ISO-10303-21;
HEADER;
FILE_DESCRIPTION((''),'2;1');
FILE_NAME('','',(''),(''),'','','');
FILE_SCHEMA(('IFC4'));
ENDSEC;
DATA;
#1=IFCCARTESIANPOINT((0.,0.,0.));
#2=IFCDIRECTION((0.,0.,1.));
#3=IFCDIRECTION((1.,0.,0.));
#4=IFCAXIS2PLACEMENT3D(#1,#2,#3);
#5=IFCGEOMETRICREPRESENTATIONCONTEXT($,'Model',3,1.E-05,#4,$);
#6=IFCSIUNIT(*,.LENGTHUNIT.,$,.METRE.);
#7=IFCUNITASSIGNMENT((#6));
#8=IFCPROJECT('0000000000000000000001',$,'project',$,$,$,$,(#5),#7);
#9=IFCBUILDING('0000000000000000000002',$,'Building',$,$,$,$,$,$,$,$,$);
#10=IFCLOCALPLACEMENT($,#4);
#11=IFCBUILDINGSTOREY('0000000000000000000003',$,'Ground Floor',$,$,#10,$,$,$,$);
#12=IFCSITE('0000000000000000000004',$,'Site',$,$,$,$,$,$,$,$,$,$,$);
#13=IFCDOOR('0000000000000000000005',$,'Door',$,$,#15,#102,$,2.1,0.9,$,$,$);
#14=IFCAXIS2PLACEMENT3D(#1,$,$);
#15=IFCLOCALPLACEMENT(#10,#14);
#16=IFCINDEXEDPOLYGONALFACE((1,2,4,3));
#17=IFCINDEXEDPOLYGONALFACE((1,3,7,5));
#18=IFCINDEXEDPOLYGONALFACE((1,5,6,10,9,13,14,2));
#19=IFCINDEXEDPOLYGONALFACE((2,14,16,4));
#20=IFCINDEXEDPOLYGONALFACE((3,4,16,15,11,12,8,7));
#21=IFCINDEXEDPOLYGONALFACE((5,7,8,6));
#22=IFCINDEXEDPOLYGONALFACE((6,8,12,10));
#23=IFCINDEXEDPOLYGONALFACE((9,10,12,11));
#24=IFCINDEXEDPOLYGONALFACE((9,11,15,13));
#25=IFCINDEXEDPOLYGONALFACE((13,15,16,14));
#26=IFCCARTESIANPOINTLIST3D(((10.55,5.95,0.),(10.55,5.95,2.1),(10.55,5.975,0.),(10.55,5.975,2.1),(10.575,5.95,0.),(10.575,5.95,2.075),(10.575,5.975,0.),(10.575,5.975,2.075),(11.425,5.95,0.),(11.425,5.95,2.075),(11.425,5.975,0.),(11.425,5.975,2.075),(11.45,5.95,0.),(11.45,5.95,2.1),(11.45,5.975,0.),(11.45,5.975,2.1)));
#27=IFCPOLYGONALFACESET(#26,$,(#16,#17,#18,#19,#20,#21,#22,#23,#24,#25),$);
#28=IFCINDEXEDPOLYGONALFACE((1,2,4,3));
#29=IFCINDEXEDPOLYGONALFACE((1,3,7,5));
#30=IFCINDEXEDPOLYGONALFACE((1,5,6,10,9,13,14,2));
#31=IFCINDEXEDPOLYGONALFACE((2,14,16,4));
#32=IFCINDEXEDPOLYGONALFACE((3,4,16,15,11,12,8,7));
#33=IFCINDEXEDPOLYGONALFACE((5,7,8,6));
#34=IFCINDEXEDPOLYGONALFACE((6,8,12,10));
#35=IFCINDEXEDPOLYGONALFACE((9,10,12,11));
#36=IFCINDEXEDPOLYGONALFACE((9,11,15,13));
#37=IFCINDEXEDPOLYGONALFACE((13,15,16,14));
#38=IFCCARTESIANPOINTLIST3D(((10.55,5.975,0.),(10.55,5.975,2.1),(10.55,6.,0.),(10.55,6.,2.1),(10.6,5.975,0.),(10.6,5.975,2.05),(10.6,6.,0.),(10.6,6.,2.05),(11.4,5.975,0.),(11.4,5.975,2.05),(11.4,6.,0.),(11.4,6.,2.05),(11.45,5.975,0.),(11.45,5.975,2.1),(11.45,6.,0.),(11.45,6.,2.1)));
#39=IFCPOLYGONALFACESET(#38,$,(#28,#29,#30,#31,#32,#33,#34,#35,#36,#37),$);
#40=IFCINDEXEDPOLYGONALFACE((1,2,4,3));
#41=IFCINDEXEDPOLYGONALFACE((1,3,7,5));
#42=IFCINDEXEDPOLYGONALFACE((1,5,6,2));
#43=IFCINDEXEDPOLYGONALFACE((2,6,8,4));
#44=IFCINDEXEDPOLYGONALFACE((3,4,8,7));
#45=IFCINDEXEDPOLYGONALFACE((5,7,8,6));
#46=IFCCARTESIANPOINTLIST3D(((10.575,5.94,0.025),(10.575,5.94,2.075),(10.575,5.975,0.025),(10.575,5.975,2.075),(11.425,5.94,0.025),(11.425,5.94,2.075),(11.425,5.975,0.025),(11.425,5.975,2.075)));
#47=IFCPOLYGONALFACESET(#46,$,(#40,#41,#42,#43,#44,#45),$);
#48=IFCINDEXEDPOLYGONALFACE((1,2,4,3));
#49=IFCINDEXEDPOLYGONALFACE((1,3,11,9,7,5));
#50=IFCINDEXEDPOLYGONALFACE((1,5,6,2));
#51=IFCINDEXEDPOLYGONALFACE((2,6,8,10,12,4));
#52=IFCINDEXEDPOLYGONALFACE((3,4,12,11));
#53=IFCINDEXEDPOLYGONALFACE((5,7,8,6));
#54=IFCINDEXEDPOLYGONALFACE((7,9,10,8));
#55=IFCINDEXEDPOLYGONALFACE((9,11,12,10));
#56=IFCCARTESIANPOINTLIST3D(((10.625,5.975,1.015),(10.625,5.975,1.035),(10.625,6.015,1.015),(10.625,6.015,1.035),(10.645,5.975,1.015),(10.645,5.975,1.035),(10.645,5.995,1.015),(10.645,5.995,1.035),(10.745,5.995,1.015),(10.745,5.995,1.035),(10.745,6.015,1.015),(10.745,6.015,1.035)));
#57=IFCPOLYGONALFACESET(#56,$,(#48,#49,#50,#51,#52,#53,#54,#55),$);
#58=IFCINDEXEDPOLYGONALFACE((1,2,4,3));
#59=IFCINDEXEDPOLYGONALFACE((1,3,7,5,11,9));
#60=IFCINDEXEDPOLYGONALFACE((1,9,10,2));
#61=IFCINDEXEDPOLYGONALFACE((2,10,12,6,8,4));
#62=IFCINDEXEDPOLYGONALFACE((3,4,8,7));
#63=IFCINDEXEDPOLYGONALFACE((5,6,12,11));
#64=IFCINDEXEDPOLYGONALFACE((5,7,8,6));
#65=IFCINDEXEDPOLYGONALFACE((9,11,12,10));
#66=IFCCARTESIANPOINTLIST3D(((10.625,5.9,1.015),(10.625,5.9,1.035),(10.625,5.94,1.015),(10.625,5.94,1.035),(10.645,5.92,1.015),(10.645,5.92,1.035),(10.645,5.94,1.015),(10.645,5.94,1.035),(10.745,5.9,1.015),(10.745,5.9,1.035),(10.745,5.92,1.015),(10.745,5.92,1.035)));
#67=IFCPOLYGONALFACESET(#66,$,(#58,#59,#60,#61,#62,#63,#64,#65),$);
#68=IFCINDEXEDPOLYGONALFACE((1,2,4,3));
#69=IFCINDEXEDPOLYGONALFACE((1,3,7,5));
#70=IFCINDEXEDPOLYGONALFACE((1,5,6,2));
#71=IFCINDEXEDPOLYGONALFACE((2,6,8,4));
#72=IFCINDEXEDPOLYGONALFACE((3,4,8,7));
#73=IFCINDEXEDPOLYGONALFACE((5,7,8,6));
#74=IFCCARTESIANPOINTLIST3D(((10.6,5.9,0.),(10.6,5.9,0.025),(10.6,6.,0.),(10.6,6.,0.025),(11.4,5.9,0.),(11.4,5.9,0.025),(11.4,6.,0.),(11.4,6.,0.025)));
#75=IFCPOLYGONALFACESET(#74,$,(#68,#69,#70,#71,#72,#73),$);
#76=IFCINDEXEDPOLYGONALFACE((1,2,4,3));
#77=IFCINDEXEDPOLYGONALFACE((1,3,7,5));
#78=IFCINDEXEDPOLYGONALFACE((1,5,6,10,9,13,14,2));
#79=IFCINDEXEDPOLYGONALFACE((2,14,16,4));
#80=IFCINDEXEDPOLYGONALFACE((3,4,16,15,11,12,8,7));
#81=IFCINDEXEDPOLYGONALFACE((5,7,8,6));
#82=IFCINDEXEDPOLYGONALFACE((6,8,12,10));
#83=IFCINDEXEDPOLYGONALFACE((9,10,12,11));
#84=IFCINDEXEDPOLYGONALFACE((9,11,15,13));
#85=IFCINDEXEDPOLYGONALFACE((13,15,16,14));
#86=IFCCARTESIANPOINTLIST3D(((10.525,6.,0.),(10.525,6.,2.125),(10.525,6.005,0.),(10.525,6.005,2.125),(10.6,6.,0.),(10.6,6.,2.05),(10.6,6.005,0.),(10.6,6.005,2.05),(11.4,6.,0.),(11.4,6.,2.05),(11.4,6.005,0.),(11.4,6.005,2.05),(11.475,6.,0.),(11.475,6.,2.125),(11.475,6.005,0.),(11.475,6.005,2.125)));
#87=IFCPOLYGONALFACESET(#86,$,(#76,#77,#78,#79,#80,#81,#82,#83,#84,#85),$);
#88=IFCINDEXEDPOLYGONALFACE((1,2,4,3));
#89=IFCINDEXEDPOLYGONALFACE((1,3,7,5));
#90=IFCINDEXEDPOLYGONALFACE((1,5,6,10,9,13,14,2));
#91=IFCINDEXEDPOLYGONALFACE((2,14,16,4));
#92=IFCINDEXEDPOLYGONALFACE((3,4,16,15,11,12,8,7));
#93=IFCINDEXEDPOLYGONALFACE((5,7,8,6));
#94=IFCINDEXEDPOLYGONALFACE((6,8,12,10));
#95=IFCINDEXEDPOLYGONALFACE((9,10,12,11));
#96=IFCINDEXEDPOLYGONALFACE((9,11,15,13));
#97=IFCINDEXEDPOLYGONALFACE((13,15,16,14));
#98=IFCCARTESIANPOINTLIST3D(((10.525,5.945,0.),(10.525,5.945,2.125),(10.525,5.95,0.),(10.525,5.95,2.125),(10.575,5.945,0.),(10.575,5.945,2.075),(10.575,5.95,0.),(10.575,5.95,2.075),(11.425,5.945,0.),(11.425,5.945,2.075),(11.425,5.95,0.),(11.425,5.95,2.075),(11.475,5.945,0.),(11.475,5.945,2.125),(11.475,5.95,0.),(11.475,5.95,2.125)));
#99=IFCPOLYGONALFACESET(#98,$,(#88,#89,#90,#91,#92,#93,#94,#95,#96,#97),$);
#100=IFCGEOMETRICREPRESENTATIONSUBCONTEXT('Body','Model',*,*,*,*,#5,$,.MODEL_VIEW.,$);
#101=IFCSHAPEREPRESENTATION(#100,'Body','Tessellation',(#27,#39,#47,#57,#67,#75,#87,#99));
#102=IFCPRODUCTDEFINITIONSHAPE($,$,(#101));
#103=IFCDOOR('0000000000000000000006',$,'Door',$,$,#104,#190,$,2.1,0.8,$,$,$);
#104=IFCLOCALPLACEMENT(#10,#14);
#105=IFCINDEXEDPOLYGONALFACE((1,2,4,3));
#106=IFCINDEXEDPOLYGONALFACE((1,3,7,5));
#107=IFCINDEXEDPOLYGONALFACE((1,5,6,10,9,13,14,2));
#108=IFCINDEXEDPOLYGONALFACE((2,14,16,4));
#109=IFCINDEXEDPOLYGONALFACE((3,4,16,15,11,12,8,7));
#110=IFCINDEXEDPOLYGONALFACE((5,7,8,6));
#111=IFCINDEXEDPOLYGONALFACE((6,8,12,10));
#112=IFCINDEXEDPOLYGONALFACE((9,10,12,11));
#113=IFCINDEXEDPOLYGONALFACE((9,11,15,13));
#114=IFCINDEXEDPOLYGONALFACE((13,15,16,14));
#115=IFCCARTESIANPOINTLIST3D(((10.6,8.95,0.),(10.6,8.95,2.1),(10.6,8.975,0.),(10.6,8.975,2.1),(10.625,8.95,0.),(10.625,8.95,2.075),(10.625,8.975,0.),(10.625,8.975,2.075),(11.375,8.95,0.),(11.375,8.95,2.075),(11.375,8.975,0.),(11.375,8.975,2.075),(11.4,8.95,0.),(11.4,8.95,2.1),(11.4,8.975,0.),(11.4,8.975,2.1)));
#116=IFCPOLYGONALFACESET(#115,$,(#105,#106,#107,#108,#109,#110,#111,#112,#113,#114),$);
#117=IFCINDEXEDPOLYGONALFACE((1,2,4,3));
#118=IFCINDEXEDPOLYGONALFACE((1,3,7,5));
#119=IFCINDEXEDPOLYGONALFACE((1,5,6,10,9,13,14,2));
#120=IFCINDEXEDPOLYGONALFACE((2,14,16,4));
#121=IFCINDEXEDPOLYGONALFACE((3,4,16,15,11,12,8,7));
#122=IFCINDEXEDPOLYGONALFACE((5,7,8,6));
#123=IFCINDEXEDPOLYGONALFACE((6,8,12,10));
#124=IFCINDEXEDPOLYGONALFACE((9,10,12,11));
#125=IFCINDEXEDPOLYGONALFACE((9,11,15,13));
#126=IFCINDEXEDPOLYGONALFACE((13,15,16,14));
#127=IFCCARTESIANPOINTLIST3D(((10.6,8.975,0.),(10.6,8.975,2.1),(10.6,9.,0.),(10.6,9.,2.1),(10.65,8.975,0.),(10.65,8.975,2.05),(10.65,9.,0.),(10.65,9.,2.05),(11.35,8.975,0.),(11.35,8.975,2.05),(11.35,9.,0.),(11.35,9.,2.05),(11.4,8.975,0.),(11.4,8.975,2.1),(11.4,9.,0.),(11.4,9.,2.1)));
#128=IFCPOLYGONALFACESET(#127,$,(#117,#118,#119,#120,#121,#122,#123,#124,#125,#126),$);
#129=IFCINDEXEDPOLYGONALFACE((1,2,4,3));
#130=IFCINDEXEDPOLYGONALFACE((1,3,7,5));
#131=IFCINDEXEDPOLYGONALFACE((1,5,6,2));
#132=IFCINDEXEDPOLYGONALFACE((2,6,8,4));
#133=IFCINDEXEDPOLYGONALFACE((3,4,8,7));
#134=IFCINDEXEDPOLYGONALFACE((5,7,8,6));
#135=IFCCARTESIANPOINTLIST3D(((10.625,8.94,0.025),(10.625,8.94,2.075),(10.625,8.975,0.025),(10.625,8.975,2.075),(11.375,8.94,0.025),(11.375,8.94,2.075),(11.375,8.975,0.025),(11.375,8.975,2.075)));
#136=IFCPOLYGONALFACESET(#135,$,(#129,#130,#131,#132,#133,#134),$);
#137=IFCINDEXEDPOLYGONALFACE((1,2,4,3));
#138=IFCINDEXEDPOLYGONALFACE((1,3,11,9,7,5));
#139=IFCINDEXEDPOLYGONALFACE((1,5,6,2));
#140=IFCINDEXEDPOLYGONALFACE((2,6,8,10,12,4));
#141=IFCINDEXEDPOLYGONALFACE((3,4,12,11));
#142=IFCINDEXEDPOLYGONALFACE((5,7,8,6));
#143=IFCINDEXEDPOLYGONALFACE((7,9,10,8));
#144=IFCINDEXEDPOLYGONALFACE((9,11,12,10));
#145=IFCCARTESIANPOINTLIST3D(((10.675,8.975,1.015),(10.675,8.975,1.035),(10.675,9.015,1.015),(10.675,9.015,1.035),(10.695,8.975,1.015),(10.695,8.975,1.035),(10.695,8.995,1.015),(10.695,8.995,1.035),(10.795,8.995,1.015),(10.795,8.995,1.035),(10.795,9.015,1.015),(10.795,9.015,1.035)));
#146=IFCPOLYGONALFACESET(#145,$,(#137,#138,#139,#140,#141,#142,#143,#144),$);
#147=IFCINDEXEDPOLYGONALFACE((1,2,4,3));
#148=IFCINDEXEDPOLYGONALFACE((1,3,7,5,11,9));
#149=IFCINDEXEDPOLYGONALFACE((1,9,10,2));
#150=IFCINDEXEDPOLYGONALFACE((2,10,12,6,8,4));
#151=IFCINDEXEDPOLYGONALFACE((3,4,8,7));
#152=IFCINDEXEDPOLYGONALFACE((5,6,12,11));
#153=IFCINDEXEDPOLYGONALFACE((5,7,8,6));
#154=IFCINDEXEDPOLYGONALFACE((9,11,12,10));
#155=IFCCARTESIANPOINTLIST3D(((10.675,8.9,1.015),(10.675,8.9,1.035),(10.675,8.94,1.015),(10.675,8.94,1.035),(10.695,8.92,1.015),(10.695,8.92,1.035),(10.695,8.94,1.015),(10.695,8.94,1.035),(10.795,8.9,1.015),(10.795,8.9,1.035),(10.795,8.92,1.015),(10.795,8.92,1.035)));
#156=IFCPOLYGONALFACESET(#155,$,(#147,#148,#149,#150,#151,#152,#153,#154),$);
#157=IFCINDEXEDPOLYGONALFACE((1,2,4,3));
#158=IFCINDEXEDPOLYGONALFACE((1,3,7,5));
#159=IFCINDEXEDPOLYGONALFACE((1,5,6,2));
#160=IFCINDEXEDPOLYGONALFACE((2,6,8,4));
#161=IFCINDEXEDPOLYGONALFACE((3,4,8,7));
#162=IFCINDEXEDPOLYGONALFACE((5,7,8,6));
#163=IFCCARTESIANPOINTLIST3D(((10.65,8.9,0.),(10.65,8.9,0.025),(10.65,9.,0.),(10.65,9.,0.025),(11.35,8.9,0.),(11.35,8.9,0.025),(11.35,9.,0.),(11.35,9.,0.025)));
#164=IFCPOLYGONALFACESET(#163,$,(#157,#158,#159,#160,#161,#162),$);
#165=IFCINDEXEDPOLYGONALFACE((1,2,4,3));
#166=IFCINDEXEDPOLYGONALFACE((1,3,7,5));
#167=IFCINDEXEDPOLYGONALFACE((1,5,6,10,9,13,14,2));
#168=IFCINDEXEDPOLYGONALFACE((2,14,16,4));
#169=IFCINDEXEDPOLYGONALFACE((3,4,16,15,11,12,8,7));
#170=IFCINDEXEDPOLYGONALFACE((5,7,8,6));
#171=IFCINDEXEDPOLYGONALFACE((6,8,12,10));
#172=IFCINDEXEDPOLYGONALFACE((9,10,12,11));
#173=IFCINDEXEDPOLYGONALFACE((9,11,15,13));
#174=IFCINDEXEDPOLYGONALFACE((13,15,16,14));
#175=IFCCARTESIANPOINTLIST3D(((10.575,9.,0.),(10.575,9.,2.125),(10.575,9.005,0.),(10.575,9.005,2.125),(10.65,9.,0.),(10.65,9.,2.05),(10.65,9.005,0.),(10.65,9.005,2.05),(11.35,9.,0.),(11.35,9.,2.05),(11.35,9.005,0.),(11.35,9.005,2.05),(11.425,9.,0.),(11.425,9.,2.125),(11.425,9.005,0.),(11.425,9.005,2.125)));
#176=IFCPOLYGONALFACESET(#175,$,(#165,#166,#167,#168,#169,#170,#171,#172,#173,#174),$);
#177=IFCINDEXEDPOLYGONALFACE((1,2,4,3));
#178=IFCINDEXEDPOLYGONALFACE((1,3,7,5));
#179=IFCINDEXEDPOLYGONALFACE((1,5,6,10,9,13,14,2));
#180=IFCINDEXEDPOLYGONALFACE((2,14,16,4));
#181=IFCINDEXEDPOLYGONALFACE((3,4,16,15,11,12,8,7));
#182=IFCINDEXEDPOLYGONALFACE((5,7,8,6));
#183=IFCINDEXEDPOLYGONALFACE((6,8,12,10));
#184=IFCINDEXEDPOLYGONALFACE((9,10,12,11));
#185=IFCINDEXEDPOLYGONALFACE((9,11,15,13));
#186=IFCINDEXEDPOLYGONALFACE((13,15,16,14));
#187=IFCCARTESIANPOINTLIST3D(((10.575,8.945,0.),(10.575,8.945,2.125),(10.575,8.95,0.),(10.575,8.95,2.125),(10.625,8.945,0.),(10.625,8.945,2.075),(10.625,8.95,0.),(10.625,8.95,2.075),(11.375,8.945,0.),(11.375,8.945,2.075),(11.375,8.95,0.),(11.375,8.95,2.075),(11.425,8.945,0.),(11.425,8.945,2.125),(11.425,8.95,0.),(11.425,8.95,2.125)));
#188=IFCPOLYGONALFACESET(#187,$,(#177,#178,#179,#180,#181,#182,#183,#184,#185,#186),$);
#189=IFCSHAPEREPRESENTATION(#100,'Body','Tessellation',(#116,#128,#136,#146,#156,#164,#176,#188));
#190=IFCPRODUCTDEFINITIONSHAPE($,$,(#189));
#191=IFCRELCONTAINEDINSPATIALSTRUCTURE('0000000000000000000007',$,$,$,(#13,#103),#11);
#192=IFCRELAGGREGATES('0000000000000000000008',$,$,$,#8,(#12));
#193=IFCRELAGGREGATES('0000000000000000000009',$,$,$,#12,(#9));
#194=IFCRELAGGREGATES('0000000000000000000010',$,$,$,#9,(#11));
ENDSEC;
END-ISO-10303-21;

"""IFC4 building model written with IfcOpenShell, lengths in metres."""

from ifc_helpers import new_model, si_unit, frame, origin_with_axes, place, context, subcontext, project, spatial, line, indexed_curve, outline, extrude, element, save


model = new_model("IFC4")

# Units and contexts
model_context = context("Model", 3, precision=1e-05, world=origin_with_axes())
body_context = subcontext(model_context, "Body", "Model", "MODEL_VIEW")
ifc_project = project(units=[si_unit("LENGTHUNIT", "METRE")], contexts=[model_context])

# Site, building, storey
site = spatial("IfcSite", under=ifc_project, Name="Site")
building = spatial("IfcBuilding", under=site, Name="Building")
storey_placement = place(None, origin_with_axes())
storey = spatial("IfcBuildingStorey", under=building, at=storey_placement, Name="Ground Floor")

# Doors
door_1_placement = place(storey_placement, frame((11.45, 6.0, 0.0), z_axis=(0.0, 0.0, 1.0), x_axis=(-1.0, 0.0, 0.0)))
element("IfcDoor", 1, at=door_1_placement, inside=storey, Name="Door", OverallHeight=2.1, OverallWidth=0.9, context=body_context, shape_type="SweptSolid", body=[
    extrude(outline(indexed_curve([(0.0, 0.0), (0.0, 2.1), (0.9, 2.1), (0.9, 0.0), (0.875, 0.0), (0.875, 2.075), (0.025, 2.075), (0.025, 0.0)], segments=[line(1, 2, 3, 4, 5, 6, 7, 8, 1)])), frame((0.0, 0.025, 0.0), z_axis=(0.0, -1.0, 0.0), x_axis=(1.0, 0.0, 0.0)), (0.0, 0.0, -1.0), 0.025),
    extrude(outline(indexed_curve([(0.0, 0.0), (0.0, 2.1), (0.9, 2.1), (0.9, 0.0), (0.85, 0.0), (0.85, 2.05), (0.05, 2.05), (0.05, 0.0)], segments=[line(1, 2, 3, 4, 5, 6, 7, 8, 1)])), frame((0.0, 0.0, 0.0), z_axis=(0.0, -1.0, 0.0), x_axis=(1.0, 0.0, 0.0)), (0.0, 0.0, -1.0), 0.025),
    extrude(outline(indexed_curve([(0.0, 0.0), (0.85, 0.0), (0.85, 0.035), (0.0, 0.035)], segments=[line(1, 2, 3, 4, 1)])), frame((0.025, 0.025, 0.025), z_axis=(0.0, 0.0, 1.0), x_axis=(1.0, 0.0, 0.0)), (0.0, 0.0, 1.0), 2.05),
    extrude(outline(indexed_curve([(0.0, 0.0), (0.0, -0.04), (-0.12, -0.04), (-0.12, -0.02), (-0.02, -0.02), (-0.02, 0.0)], segments=[line(1, 2, 3, 4, 5, 6, 1)])), frame((0.825, 0.025, 1.015), z_axis=(0.0, 0.0, 1.0), x_axis=(1.0, 0.0, 0.0)), (0.0, 0.0, 1.0), 0.02),
    extrude(outline(indexed_curve([(0.0, 0.0), (0.0, 0.04), (-0.12, 0.04), (-0.12, 0.02), (-0.02, 0.02), (-0.02, 0.0)], segments=[line(1, 2, 3, 4, 5, 6, 1)])), frame((0.825, 0.06, 1.015), z_axis=(0.0, 0.0, 1.0), x_axis=(1.0, 0.0, 0.0)), (0.0, 0.0, 1.0), 0.02),
    extrude(outline(indexed_curve([(0.0, 0.0), (0.8, 0.0), (0.8, 0.1), (0.0, 0.1)], segments=[line(1, 2, 3, 4, 1)])), frame((0.05, 0.0, 0.0), z_axis=(0.0, 0.0, 1.0), x_axis=(1.0, 0.0, 0.0)), (0.0, 0.0, 1.0), 0.025),
    extrude(outline(indexed_curve([(0.0, 0.0), (0.0, 2.125), (0.95, 2.125), (0.95, 0.0), (0.875, 0.0), (0.875, 2.05), (0.075, 2.05), (0.075, 0.0)], segments=[line(1, 2, 3, 4, 5, 6, 7, 8, 1)])), frame((-0.025, -0.005, 0.0), z_axis=(0.0, -1.0, 0.0), x_axis=(1.0, 0.0, 0.0)), (0.0, 0.0, -1.0), 0.005),
    extrude(outline(indexed_curve([(0.0, 0.0), (0.0, 2.125), (0.95, 2.125), (0.95, 0.0), (0.9, 0.0), (0.9, 2.075), (0.05, 2.075), (0.05, 0.0)], segments=[line(1, 2, 3, 4, 5, 6, 7, 8, 1)])), frame((-0.025, 0.05, 0.0), z_axis=(0.0, -1.0, 0.0), x_axis=(1.0, 0.0, 0.0)), (0.0, 0.0, -1.0), 0.005),
])
door_2_placement = place(storey_placement, frame((11.4, 9.0, 0.0), z_axis=(0.0, 0.0, 1.0), x_axis=(-1.0, 0.0, 0.0)))
element("IfcDoor", 2, at=door_2_placement, inside=storey, Name="Door", OverallHeight=2.1, OverallWidth=0.8, context=body_context, shape_type="SweptSolid", body=[
    extrude(outline(indexed_curve([(0.0, 0.0), (0.0, 2.1), (0.8, 2.1), (0.8, 0.0), (0.775, 0.0), (0.775, 2.075), (0.025, 2.075), (0.025, 0.0)], segments=[line(1, 2, 3, 4, 5, 6, 7, 8, 1)])), frame((0.0, 0.025, 0.0), z_axis=(0.0, -1.0, 0.0), x_axis=(1.0, 0.0, 0.0)), (0.0, 0.0, -1.0), 0.025),
    extrude(outline(indexed_curve([(0.0, 0.0), (0.0, 2.1), (0.8, 2.1), (0.8, 0.0), (0.75, 0.0), (0.75, 2.05), (0.05, 2.05), (0.05, 0.0)], segments=[line(1, 2, 3, 4, 5, 6, 7, 8, 1)])), frame((0.0, 0.0, 0.0), z_axis=(0.0, -1.0, 0.0), x_axis=(1.0, 0.0, 0.0)), (0.0, 0.0, -1.0), 0.025),
    extrude(outline(indexed_curve([(0.0, 0.0), (0.75, 0.0), (0.75, 0.035), (0.0, 0.035)], segments=[line(1, 2, 3, 4, 1)])), frame((0.025, 0.025, 0.025), z_axis=(0.0, 0.0, 1.0), x_axis=(1.0, 0.0, 0.0)), (0.0, 0.0, 1.0), 2.05),
    extrude(outline(indexed_curve([(0.0, 0.0), (0.0, -0.04), (-0.12, -0.04), (-0.12, -0.02), (-0.02, -0.02), (-0.02, 0.0)], segments=[line(1, 2, 3, 4, 5, 6, 1)])), frame((0.725, 0.025, 1.015), z_axis=(0.0, 0.0, 1.0), x_axis=(1.0, 0.0, 0.0)), (0.0, 0.0, 1.0), 0.02),
    extrude(outline(indexed_curve([(0.0, 0.0), (0.0, 0.04), (-0.12, 0.04), (-0.12, 0.02), (-0.02, 0.02), (-0.02, 0.0)], segments=[line(1, 2, 3, 4, 5, 6, 1)])), frame((0.725, 0.06, 1.015), z_axis=(0.0, 0.0, 1.0), x_axis=(1.0, 0.0, 0.0)), (0.0, 0.0, 1.0), 0.02),
    extrude(outline(indexed_curve([(0.0, 0.0), (0.7, 0.0), (0.7, 0.1), (0.0, 0.1)], segments=[line(1, 2, 3, 4, 1)])), frame((0.05, 0.0, 0.0), z_axis=(0.0, 0.0, 1.0), x_axis=(1.0, 0.0, 0.0)), (0.0, 0.0, 1.0), 0.025),
    extrude(outline(indexed_curve([(0.0, 0.0), (0.0, 2.125), (0.85, 2.125), (0.85, 0.0), (0.775, 0.0), (0.775, 2.05), (0.075, 2.05), (0.075, 0.0)], segments=[line(1, 2, 3, 4, 5, 6, 7, 8, 1)])), frame((-0.025, -0.005, 0.0), z_axis=(0.0, -1.0, 0.0), x_axis=(1.0, 0.0, 0.0)), (0.0, 0.0, -1.0), 0.005),
    extrude(outline(indexed_curve([(0.0, 0.0), (0.0, 2.125), (0.85, 2.125), (0.85, 0.0), (0.8, 0.0), (0.8, 2.075), (0.05, 2.075), (0.05, 0.0)], segments=[line(1, 2, 3, 4, 5, 6, 7, 8, 1)])), frame((-0.025, 0.05, 0.0), z_axis=(0.0, -1.0, 0.0), x_axis=(1.0, 0.0, 0.0)), (0.0, 0.0, -1.0), 0.005),
])

save(model, "model.ifc")
